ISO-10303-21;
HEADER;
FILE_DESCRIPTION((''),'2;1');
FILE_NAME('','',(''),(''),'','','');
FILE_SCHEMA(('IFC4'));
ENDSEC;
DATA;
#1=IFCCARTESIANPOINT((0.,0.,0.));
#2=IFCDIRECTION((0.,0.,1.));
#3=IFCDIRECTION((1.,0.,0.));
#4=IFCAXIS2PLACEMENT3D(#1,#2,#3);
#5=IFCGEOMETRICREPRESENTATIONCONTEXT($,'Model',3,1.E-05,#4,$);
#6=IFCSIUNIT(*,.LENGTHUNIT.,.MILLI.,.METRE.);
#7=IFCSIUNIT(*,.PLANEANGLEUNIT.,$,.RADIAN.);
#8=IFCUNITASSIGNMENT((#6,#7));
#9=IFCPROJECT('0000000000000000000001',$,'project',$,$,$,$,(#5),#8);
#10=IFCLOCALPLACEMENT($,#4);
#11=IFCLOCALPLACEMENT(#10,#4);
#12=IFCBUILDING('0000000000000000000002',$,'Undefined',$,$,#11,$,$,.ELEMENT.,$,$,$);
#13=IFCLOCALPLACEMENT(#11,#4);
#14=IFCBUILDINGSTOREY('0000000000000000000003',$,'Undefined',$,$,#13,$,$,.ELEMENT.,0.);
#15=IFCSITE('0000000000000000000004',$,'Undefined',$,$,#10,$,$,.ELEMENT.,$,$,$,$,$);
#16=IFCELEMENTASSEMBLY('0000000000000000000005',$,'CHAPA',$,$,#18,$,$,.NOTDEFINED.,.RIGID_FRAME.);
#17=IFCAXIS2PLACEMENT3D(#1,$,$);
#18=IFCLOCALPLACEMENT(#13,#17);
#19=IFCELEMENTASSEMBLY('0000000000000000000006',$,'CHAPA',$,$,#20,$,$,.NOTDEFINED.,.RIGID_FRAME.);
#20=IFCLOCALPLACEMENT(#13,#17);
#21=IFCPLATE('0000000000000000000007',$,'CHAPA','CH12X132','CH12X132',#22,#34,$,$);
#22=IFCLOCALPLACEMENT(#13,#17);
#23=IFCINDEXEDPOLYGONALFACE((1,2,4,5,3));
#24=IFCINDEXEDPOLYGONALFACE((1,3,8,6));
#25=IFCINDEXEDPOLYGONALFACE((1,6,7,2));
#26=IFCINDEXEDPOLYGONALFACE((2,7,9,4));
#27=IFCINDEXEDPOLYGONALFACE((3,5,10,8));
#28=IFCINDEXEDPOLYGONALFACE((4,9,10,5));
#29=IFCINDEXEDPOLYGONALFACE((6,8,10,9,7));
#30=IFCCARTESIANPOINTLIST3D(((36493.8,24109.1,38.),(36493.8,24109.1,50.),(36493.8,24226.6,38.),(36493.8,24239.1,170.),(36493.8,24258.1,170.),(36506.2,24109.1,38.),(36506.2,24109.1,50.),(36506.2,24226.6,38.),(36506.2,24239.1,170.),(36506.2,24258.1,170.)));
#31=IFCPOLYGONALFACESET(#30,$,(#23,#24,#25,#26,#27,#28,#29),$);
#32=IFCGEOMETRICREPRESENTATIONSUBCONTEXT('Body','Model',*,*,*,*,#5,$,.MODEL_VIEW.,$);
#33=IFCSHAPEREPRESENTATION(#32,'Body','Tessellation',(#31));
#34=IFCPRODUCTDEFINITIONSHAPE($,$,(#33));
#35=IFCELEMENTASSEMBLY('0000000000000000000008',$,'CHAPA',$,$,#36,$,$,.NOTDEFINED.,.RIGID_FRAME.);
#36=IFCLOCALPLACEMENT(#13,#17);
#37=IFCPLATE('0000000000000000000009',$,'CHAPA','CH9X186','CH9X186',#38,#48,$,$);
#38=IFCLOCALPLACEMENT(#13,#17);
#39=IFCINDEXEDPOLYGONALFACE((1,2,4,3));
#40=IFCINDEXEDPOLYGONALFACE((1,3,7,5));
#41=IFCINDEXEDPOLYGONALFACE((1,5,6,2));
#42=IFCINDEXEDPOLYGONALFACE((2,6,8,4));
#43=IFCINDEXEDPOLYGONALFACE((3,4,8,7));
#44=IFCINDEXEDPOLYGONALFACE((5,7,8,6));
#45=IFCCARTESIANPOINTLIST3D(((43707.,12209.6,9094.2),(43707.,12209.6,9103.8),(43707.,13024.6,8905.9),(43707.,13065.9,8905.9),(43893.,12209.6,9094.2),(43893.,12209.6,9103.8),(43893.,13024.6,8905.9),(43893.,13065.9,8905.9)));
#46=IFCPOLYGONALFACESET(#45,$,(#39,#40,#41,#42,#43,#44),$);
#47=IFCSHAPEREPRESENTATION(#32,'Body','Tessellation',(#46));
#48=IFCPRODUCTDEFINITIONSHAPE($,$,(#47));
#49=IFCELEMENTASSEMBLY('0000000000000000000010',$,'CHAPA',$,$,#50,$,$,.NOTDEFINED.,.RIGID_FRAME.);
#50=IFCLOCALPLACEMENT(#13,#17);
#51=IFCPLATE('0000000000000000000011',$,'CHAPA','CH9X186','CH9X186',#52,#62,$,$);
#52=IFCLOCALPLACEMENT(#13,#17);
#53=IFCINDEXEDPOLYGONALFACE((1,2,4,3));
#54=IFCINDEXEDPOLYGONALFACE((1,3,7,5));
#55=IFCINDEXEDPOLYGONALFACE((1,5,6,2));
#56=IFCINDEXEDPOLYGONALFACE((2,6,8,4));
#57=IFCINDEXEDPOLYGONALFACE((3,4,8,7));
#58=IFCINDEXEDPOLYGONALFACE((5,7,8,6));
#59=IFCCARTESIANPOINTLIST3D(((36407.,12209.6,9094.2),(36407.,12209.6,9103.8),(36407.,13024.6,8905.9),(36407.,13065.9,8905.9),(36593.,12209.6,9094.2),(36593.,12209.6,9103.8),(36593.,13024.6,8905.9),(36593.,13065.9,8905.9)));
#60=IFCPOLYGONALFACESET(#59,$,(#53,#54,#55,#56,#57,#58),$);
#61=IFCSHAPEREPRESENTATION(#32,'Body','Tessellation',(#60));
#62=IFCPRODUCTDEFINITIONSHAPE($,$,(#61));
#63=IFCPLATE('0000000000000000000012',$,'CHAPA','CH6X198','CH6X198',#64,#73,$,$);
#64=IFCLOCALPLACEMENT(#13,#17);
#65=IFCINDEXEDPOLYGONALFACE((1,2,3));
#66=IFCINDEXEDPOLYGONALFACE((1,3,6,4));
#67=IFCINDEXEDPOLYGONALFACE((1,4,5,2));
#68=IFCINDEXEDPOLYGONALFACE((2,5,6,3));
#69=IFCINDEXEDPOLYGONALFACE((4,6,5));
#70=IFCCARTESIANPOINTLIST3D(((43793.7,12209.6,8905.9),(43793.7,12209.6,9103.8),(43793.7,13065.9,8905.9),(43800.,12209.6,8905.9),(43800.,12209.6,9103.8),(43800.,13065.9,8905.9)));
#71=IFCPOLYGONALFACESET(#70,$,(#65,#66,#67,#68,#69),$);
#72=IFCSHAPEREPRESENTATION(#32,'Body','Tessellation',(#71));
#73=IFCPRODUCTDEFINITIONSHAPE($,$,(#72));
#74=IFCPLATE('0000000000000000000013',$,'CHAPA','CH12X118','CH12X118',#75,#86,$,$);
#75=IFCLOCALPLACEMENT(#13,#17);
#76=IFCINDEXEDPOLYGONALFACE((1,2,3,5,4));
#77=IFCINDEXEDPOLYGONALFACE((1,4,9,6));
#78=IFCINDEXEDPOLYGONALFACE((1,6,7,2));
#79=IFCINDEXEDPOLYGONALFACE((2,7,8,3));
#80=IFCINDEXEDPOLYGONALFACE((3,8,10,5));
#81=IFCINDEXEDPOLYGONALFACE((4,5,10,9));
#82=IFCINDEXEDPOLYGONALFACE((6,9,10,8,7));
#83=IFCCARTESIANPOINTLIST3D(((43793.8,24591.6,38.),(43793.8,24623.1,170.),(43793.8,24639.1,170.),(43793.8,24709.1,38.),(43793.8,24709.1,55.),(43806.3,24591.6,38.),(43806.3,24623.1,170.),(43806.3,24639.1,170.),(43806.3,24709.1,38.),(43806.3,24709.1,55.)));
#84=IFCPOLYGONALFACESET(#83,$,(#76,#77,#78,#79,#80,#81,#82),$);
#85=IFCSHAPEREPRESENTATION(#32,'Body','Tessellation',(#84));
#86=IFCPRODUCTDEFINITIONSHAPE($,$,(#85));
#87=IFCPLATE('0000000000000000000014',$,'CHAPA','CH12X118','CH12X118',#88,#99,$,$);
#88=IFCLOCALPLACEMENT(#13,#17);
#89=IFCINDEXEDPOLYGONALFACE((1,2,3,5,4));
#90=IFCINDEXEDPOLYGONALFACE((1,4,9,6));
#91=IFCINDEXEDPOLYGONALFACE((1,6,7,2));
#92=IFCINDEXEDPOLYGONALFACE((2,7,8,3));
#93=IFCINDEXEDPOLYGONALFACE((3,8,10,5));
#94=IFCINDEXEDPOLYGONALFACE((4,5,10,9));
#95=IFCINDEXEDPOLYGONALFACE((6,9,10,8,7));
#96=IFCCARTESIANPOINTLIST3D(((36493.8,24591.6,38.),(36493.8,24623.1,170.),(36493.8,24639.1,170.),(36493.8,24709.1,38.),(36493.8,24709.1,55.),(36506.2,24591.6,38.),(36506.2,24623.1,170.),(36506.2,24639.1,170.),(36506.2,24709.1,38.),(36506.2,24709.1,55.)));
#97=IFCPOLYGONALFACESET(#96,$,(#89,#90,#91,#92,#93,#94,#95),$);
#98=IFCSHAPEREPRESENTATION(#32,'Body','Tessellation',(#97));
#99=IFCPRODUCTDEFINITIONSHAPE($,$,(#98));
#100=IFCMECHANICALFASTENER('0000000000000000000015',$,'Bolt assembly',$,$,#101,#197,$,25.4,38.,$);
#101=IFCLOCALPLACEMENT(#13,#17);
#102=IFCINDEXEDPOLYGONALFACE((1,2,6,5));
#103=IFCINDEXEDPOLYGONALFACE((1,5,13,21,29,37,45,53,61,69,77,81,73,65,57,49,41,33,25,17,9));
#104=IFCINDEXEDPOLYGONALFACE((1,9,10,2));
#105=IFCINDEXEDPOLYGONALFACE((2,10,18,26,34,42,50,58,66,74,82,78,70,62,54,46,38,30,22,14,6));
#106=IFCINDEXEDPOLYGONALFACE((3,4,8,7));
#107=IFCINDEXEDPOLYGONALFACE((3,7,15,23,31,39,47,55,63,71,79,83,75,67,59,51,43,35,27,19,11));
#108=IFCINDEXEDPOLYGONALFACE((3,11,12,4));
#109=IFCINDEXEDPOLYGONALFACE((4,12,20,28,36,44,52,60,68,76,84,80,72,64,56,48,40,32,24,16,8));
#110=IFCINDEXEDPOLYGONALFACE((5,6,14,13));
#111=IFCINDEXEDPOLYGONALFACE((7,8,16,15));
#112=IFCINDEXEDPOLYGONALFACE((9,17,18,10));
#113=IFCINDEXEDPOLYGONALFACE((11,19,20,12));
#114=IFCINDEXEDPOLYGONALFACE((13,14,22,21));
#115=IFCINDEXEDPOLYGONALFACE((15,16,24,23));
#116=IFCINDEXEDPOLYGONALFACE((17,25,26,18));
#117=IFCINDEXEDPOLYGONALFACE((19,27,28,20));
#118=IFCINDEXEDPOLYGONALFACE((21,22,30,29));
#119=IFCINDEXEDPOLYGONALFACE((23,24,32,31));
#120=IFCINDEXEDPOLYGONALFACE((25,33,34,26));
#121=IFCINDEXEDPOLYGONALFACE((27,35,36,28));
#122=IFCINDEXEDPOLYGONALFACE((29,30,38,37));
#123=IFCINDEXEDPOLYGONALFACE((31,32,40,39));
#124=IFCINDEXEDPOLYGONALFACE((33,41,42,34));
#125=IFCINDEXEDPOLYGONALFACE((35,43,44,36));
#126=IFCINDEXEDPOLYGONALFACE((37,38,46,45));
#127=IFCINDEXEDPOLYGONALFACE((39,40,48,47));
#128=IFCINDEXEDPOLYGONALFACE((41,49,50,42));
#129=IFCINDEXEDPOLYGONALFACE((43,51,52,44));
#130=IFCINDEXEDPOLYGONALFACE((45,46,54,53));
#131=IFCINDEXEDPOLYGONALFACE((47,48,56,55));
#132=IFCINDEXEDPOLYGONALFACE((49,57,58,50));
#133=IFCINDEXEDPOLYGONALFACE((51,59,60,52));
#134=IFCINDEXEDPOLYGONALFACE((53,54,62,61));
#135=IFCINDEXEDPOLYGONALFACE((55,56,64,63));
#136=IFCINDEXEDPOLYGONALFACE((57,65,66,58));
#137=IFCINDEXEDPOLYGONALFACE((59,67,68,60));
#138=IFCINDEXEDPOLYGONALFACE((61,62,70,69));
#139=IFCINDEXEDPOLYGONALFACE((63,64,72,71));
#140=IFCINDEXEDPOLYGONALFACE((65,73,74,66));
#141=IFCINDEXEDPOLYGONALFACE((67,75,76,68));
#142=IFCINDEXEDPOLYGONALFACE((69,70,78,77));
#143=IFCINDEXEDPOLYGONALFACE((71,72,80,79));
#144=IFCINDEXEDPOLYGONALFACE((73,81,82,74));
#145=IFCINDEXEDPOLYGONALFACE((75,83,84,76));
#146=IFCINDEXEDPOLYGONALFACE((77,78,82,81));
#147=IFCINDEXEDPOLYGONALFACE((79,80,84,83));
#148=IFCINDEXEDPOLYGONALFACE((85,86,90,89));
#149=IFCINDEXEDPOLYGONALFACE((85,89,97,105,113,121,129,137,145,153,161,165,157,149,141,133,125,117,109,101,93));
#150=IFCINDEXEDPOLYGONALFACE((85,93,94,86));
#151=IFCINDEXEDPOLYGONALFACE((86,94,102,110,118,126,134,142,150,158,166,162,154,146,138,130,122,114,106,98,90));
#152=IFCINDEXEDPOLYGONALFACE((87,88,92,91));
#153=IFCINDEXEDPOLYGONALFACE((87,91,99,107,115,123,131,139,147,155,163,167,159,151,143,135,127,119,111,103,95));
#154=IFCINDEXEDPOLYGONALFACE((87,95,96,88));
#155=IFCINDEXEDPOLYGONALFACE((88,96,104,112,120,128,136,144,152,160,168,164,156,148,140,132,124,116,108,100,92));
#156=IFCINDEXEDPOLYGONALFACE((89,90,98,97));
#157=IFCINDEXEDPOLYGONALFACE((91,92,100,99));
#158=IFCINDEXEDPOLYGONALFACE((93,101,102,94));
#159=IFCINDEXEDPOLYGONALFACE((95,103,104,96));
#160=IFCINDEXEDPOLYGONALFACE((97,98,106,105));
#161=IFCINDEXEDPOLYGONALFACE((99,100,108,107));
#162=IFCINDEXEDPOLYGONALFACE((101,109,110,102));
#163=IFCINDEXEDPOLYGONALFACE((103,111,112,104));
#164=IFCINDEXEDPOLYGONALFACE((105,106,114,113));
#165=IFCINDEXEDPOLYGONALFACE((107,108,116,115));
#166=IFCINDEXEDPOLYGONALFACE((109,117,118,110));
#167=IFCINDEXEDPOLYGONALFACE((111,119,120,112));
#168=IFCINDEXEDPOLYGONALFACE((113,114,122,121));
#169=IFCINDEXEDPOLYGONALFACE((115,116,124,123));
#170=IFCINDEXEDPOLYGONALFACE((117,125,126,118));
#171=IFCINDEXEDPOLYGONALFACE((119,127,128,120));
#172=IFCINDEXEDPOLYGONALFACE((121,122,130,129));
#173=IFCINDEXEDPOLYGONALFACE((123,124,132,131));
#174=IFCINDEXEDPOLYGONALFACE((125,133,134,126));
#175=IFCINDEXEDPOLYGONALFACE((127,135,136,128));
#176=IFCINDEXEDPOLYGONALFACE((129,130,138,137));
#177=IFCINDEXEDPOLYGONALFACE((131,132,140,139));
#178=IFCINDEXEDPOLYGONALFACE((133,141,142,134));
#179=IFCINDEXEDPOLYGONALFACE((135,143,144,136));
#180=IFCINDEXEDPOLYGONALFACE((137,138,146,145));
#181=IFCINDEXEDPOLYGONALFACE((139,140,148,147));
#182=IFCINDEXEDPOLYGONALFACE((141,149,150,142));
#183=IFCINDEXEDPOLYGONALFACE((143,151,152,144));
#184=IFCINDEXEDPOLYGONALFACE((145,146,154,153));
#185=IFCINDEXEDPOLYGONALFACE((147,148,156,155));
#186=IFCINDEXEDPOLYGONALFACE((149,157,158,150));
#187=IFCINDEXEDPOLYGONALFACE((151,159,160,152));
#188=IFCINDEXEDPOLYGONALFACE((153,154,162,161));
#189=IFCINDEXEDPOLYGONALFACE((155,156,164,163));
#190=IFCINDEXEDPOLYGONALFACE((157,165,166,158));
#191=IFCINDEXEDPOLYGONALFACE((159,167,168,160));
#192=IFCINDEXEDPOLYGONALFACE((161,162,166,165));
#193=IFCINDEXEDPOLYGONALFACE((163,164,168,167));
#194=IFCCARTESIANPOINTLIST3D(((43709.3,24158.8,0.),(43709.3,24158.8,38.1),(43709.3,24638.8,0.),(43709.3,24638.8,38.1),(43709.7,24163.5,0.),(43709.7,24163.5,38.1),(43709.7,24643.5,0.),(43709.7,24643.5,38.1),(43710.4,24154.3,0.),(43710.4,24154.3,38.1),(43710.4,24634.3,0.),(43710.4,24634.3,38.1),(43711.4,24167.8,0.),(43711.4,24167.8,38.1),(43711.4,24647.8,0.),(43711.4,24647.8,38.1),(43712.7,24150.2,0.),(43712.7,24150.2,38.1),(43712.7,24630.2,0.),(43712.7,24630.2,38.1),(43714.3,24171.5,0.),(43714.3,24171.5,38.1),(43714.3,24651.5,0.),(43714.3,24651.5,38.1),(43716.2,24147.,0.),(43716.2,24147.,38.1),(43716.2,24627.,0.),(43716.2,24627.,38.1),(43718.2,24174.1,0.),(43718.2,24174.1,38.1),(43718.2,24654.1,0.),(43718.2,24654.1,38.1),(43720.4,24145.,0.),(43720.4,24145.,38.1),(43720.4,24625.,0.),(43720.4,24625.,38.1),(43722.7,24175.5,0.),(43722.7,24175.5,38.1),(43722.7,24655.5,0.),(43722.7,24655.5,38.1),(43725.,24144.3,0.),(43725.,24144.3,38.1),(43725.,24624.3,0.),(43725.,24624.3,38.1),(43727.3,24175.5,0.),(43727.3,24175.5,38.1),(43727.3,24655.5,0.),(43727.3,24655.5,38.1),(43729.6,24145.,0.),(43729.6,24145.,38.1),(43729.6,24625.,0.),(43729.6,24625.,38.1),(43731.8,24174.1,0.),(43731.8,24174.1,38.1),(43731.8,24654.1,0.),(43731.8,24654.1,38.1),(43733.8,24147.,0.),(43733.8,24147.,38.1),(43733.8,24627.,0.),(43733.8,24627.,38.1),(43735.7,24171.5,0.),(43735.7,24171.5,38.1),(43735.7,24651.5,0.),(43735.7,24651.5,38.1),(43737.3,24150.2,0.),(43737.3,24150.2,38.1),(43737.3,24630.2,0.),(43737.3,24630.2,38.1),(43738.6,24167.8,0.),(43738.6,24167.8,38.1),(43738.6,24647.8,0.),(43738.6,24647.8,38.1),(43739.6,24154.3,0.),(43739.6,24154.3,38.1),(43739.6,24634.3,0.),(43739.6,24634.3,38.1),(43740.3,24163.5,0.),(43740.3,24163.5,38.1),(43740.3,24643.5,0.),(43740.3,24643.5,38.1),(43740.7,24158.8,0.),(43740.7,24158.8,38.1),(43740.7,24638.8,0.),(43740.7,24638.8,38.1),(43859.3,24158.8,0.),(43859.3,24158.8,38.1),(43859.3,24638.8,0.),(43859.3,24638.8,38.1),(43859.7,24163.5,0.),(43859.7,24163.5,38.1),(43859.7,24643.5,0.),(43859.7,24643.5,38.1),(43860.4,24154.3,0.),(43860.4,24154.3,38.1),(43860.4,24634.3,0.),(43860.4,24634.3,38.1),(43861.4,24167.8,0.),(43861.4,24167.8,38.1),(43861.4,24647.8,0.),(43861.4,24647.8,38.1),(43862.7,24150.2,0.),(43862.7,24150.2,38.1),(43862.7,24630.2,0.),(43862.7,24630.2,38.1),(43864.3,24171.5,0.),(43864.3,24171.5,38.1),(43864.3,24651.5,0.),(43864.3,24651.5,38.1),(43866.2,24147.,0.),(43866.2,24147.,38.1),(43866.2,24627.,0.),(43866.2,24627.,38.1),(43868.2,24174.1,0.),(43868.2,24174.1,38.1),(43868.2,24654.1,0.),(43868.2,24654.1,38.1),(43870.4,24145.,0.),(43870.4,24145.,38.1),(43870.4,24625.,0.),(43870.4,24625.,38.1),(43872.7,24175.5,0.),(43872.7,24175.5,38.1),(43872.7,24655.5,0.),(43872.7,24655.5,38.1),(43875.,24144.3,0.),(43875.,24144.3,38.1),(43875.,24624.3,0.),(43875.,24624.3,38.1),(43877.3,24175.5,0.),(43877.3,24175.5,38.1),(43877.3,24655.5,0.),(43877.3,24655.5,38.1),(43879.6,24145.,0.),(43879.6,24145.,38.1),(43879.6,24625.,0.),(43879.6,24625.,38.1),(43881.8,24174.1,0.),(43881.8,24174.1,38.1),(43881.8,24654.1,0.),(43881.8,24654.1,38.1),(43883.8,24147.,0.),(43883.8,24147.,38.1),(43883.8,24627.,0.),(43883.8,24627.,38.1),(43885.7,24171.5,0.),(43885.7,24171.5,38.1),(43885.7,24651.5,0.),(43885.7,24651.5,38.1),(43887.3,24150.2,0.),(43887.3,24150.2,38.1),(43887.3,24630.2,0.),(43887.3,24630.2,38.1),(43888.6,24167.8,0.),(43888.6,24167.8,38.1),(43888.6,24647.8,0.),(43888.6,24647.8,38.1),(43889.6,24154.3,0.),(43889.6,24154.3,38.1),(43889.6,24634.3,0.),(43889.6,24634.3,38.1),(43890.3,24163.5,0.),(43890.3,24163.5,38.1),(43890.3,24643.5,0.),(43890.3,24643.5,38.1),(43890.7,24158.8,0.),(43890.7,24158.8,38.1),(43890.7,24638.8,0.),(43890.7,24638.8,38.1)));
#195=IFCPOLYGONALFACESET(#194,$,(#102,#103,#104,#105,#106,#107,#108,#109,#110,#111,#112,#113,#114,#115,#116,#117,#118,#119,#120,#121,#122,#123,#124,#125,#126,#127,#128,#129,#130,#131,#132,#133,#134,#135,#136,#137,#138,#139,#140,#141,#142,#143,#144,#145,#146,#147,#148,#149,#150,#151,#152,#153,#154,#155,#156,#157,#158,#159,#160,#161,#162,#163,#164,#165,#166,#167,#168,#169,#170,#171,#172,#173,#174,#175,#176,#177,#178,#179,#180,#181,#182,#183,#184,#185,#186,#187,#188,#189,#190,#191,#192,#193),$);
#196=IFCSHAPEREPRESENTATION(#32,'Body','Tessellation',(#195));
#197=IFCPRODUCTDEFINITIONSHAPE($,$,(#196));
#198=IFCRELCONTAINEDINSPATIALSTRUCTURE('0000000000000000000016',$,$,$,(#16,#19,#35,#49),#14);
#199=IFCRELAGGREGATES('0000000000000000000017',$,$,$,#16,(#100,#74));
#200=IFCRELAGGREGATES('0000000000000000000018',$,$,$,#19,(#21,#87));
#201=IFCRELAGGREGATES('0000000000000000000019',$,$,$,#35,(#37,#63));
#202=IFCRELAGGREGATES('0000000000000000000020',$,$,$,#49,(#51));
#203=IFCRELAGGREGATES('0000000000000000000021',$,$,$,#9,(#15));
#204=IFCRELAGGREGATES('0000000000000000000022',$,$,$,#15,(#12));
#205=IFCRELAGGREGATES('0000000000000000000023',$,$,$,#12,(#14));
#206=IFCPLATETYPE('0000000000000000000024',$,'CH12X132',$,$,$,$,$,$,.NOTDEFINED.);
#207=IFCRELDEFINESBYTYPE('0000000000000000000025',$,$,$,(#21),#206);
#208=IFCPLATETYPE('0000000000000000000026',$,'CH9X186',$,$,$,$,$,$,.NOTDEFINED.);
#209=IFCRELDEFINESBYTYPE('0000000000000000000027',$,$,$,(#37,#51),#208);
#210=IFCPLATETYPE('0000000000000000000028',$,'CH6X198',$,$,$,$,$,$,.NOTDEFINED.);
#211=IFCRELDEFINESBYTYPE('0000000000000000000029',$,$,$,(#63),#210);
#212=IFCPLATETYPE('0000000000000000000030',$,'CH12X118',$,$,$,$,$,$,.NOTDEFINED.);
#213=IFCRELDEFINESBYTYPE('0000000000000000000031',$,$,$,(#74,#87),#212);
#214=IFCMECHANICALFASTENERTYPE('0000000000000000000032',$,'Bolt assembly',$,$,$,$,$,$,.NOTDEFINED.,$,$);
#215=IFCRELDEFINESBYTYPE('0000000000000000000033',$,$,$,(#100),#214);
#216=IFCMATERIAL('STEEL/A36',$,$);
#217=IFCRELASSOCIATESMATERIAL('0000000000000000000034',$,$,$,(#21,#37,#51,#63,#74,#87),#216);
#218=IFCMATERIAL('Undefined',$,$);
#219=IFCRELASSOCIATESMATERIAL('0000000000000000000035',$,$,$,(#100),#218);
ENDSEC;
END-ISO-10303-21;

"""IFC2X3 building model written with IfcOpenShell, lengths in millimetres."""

from ifc_helpers import new_model, si_unit, frame, origin_with_axes, origin_2d_with_axis, place, context, subcontext, project, spatial, polyline, circle, outline, extrude, clip, halfspace, source, transform, mapped, material, type_object, element, aggregate, save


model = new_model("IFC2X3")

# Units and contexts
model_context = context("Model", 3, precision=1e-05, world=origin_with_axes())
body_context = subcontext(model_context, "Body", "Model", "MODEL_VIEW")
ifc_project = project(units=[si_unit("LENGTHUNIT", "METRE", prefix="MILLI"), si_unit("PLANEANGLEUNIT", "RADIAN")], contexts=[model_context])

# Site, building, storey
site_placement = place(None, origin_with_axes())
site = spatial("IfcSite", under=ifc_project, at=site_placement, Name="Undefined", CompositionType="ELEMENT")
building_placement = place(site_placement, origin_with_axes())
building = spatial("IfcBuilding", under=site, at=building_placement, Name="Undefined", CompositionType="ELEMENT")
storey_placement = place(building_placement, origin_with_axes())
storey = spatial("IfcBuildingStorey", under=building, at=storey_placement, Name="Undefined", CompositionType="ELEMENT", Elevation=0.0)

# Element assemblies
assembly_1_placement = place(storey_placement, origin_with_axes())
assembly_1 = element("IfcElementAssembly", 1, at=assembly_1_placement, inside=storey, Name="CHAPA", AssemblyPlace="NOTDEFINED", PredefinedType="RIGID_FRAME")
assembly_2_placement = place(storey_placement, origin_with_axes())
assembly_2 = element("IfcElementAssembly", 2, at=assembly_2_placement, inside=storey, Name="CHAPA", AssemblyPlace="NOTDEFINED", PredefinedType="RIGID_FRAME")

# Plate
ifc_material_1 = material(Name="STEEL/A36")
plate_type_1 = type_object("IfcPlateType", Name="CH12X132", PredefinedType="NOTDEFINED")
plate_1_placement = place(assembly_2_placement, frame((36500.0, 24226.6, 38.0), z_axis=(-1.0, 0.0, 0.0), x_axis=(0.0, -1.0, 0.0)))
plate_1 = element("IfcPlate", 3, at=plate_1_placement, type_object=plate_type_1, material=ifc_material_1, Name="CHAPA", Description="CH12X132", ObjectType="CH12X132", context=body_context, shape_type="SweptSolid", body=[
    extrude(outline(polyline([(0.0, 0.0), (117.5, 0.0), (117.5, 12.0), (-12.5, 132.0), (-31.6, 132.0), (0.0, 0.0)])), frame((0.0, 0.0, -6.2), z_axis=(0.0, 0.0, 1.0), x_axis=(1.0, 0.0, 0.0)), (0.0, 0.0, 1.0), 12.5),
])

# Element assemblies, plates
assembly_3_placement = place(storey_placement, origin_with_axes())
assembly_3 = element("IfcElementAssembly", 4, at=assembly_3_placement, inside=storey, Name="CHAPA", AssemblyPlace="NOTDEFINED", PredefinedType="RIGID_FRAME")
plate_type_2 = type_object("IfcPlateType", Name="CH9X186", PredefinedType="NOTDEFINED")
plate_2_placement = place(assembly_3_placement, frame((43893.0, 12208.6, 9099.3), z_axis=(0.0, -0.225125, -0.97433), x_axis=(-1.0, 0.0, 0.0)))
plate_2 = element("IfcPlate", 5, at=plate_2_placement, type_object=plate_type_2, material=ifc_material_1, Name="CHAPA", Description="CH9X186", ObjectType="CH9X186", context=body_context, shape_type="Clipping", body=[
    clip(clip(extrude(outline(polyline([(0.0, 0.0), (186.0, 0.0), (186.0, 878.9), (0.0, 878.9), (0.0, 0.0)])), frame((0.0, 0.0, -4.7), z_axis=(0.0, 0.0, 1.0), x_axis=(1.0, 0.0, 0.0)), (0.0, 0.0, 1.0), 9.3), halfspace(frame((186.0, -500.0, 314.0), z_axis=(0.0, 0.225128, 0.974329), x_axis=(-1.0, 0.0, 0.0)), False)), halfspace(frame((0.0, 2.1, 4.7), z_axis=(0.0, -0.97433, 0.225125), x_axis=(1.0, 0.0, 0.0)), False)),
])
assembly_4_placement = place(storey_placement, origin_with_axes())
assembly_4 = element("IfcElementAssembly", 6, at=assembly_4_placement, inside=storey, Name="CHAPA", AssemblyPlace="NOTDEFINED", PredefinedType="RIGID_FRAME")
plate_3_placement = place(assembly_4_placement, frame((36593.0, 12208.6, 9099.3), z_axis=(0.0, -0.225125, -0.97433), x_axis=(-1.0, 0.0, 0.0)))
plate_3 = element("IfcPlate", 7, at=plate_3_placement, type_object=plate_type_2, material=ifc_material_1, Name="CHAPA", Description="CH9X186", ObjectType="CH9X186", context=body_context, shape_type="Clipping", body=[
    clip(clip(extrude(outline(polyline([(0.0, 0.0), (186.0, 0.0), (186.0, 878.9), (0.0, 878.9), (0.0, 0.0)])), frame((0.0, 0.0, -4.7), z_axis=(0.0, 0.0, 1.0), x_axis=(1.0, 0.0, 0.0)), (0.0, 0.0, 1.0), 9.3), halfspace(frame((186.0, -500.0, 314.0), z_axis=(0.0, 0.225128, 0.974329), x_axis=(-1.0, 0.0, 0.0)), False)), halfspace(frame((0.0, 2.1, 4.7), z_axis=(0.0, -0.97433, 0.225125), x_axis=(1.0, 0.0, 0.0)), False)),
])

# Plates
plate_type_3 = type_object("IfcPlateType", Name="CH6X198", PredefinedType="NOTDEFINED")
plate_4_placement = place(assembly_3_placement, frame((43796.8, 13065.9, 8905.9), z_axis=(-1.0, 0.0, 0.0), x_axis=(0.0, -1.0, 0.0)))
plate_4 = element("IfcPlate", 8, at=plate_4_placement, type_object=plate_type_3, material=ifc_material_1, Name="CHAPA", Description="CH6X198", ObjectType="CH6X198", context=body_context, shape_type="SweptSolid", body=[
    extrude(outline(polyline([(0.0, 0.0), (856.3, 0.0), (856.3, 197.9), (0.0, 0.0)])), frame((0.0, 0.0, -3.1), z_axis=(0.0, 0.0, 1.0), x_axis=(1.0, 0.0, 0.0)), (0.0, 0.0, 1.0), 6.3),
])
plate_type_4 = type_object("IfcPlateType", Name="CH12X118", PredefinedType="NOTDEFINED")
plate_5_placement = place(assembly_1_placement, frame((43800.0, 24709.1, 38.0), z_axis=(-1.0, 0.0, 0.0), x_axis=(0.0, -1.0, 0.0)))
plate_5 = element("IfcPlate", 9, at=plate_5_placement, type_object=plate_type_4, material=ifc_material_1, Name="CHAPA", Description="CH12X118", ObjectType="CH12X118", context=body_context, shape_type="SweptSolid", body=[
    extrude(outline(polyline([(0.0, 0.0), (117.5, 0.0), (85.9, 132.0), (70.0, 132.0), (0.0, 17.0), (0.0, 0.0)])), frame((0.0, 0.0, -6.2), z_axis=(0.0, 0.0, 1.0), x_axis=(1.0, 0.0, 0.0)), (0.0, 0.0, 1.0), 12.5),
])
plate_6_placement = place(assembly_2_placement, frame((36500.0, 24709.1, 38.0), z_axis=(-1.0, 0.0, 0.0), x_axis=(0.0, -1.0, 0.0)))
plate_6 = element("IfcPlate", 10, at=plate_6_placement, type_object=plate_type_4, material=ifc_material_1, Name="CHAPA", Description="CH12X118", ObjectType="CH12X118", context=body_context, shape_type="SweptSolid", body=[
    extrude(outline(polyline([(0.0, 0.0), (117.5, 0.0), (85.9, 132.0), (70.0, 132.0), (0.0, 17.0), (0.0, 0.0)])), frame((0.0, 0.0, -6.2), z_axis=(0.0, 0.0, 1.0), x_axis=(1.0, 0.0, 0.0)), (0.0, 0.0, 1.0), 12.5),
])

# Shared definitions
ifc_material_2 = material(Name="Undefined")
mechanical_fastener_type = type_object("IfcMechanicalFastenerType", Name="Bolt assembly")

# Mechanical fastener
shared_shape_1 = source(origin_with_axes(), body_context, "Body", "SweptSolid", [
    extrude(circle(Radius=15.7, at=origin_2d_with_axis()), frame((0.0, -38.0, 0.0), z_axis=(0.0, 1.0, 0.0), x_axis=(1.0, 0.0, 0.0)), (0.0, 0.0, 1.0), 38.1),
])
mechanical_fastener_1_placement = place(assembly_1_placement, frame((43800.0, 24640.0, 38.0), z_axis=(-1.0, 0.0, 0.0), x_axis=(0.0, -1.0, 0.0)))
mechanical_fastener_1 = element("IfcMechanicalFastener", 11, at=mechanical_fastener_1_placement, type_object=mechanical_fastener_type, material=ifc_material_2, Name="Bolt assembly", NominalDiameter=25.4, NominalLength=38.0, context=body_context, shape_type="MappedRepresentation", body=[
    mapped(shared_shape_1, transform((0.0, 0.0, -75.0))),
    mapped(shared_shape_1, transform((0.0, 0.0, 75.0))),
    mapped(shared_shape_1, transform((480.0, 0.0, -75.0))),
    mapped(shared_shape_1, transform((480.0, 0.0, 75.0))),
])
aggregate(assembly_1, [mechanical_fastener_1, plate_5])
aggregate(assembly_2, [plate_1, plate_6])
aggregate(assembly_3, [plate_2, plate_4])
aggregate(assembly_4, [plate_3])

save(model, "model.ifc")
